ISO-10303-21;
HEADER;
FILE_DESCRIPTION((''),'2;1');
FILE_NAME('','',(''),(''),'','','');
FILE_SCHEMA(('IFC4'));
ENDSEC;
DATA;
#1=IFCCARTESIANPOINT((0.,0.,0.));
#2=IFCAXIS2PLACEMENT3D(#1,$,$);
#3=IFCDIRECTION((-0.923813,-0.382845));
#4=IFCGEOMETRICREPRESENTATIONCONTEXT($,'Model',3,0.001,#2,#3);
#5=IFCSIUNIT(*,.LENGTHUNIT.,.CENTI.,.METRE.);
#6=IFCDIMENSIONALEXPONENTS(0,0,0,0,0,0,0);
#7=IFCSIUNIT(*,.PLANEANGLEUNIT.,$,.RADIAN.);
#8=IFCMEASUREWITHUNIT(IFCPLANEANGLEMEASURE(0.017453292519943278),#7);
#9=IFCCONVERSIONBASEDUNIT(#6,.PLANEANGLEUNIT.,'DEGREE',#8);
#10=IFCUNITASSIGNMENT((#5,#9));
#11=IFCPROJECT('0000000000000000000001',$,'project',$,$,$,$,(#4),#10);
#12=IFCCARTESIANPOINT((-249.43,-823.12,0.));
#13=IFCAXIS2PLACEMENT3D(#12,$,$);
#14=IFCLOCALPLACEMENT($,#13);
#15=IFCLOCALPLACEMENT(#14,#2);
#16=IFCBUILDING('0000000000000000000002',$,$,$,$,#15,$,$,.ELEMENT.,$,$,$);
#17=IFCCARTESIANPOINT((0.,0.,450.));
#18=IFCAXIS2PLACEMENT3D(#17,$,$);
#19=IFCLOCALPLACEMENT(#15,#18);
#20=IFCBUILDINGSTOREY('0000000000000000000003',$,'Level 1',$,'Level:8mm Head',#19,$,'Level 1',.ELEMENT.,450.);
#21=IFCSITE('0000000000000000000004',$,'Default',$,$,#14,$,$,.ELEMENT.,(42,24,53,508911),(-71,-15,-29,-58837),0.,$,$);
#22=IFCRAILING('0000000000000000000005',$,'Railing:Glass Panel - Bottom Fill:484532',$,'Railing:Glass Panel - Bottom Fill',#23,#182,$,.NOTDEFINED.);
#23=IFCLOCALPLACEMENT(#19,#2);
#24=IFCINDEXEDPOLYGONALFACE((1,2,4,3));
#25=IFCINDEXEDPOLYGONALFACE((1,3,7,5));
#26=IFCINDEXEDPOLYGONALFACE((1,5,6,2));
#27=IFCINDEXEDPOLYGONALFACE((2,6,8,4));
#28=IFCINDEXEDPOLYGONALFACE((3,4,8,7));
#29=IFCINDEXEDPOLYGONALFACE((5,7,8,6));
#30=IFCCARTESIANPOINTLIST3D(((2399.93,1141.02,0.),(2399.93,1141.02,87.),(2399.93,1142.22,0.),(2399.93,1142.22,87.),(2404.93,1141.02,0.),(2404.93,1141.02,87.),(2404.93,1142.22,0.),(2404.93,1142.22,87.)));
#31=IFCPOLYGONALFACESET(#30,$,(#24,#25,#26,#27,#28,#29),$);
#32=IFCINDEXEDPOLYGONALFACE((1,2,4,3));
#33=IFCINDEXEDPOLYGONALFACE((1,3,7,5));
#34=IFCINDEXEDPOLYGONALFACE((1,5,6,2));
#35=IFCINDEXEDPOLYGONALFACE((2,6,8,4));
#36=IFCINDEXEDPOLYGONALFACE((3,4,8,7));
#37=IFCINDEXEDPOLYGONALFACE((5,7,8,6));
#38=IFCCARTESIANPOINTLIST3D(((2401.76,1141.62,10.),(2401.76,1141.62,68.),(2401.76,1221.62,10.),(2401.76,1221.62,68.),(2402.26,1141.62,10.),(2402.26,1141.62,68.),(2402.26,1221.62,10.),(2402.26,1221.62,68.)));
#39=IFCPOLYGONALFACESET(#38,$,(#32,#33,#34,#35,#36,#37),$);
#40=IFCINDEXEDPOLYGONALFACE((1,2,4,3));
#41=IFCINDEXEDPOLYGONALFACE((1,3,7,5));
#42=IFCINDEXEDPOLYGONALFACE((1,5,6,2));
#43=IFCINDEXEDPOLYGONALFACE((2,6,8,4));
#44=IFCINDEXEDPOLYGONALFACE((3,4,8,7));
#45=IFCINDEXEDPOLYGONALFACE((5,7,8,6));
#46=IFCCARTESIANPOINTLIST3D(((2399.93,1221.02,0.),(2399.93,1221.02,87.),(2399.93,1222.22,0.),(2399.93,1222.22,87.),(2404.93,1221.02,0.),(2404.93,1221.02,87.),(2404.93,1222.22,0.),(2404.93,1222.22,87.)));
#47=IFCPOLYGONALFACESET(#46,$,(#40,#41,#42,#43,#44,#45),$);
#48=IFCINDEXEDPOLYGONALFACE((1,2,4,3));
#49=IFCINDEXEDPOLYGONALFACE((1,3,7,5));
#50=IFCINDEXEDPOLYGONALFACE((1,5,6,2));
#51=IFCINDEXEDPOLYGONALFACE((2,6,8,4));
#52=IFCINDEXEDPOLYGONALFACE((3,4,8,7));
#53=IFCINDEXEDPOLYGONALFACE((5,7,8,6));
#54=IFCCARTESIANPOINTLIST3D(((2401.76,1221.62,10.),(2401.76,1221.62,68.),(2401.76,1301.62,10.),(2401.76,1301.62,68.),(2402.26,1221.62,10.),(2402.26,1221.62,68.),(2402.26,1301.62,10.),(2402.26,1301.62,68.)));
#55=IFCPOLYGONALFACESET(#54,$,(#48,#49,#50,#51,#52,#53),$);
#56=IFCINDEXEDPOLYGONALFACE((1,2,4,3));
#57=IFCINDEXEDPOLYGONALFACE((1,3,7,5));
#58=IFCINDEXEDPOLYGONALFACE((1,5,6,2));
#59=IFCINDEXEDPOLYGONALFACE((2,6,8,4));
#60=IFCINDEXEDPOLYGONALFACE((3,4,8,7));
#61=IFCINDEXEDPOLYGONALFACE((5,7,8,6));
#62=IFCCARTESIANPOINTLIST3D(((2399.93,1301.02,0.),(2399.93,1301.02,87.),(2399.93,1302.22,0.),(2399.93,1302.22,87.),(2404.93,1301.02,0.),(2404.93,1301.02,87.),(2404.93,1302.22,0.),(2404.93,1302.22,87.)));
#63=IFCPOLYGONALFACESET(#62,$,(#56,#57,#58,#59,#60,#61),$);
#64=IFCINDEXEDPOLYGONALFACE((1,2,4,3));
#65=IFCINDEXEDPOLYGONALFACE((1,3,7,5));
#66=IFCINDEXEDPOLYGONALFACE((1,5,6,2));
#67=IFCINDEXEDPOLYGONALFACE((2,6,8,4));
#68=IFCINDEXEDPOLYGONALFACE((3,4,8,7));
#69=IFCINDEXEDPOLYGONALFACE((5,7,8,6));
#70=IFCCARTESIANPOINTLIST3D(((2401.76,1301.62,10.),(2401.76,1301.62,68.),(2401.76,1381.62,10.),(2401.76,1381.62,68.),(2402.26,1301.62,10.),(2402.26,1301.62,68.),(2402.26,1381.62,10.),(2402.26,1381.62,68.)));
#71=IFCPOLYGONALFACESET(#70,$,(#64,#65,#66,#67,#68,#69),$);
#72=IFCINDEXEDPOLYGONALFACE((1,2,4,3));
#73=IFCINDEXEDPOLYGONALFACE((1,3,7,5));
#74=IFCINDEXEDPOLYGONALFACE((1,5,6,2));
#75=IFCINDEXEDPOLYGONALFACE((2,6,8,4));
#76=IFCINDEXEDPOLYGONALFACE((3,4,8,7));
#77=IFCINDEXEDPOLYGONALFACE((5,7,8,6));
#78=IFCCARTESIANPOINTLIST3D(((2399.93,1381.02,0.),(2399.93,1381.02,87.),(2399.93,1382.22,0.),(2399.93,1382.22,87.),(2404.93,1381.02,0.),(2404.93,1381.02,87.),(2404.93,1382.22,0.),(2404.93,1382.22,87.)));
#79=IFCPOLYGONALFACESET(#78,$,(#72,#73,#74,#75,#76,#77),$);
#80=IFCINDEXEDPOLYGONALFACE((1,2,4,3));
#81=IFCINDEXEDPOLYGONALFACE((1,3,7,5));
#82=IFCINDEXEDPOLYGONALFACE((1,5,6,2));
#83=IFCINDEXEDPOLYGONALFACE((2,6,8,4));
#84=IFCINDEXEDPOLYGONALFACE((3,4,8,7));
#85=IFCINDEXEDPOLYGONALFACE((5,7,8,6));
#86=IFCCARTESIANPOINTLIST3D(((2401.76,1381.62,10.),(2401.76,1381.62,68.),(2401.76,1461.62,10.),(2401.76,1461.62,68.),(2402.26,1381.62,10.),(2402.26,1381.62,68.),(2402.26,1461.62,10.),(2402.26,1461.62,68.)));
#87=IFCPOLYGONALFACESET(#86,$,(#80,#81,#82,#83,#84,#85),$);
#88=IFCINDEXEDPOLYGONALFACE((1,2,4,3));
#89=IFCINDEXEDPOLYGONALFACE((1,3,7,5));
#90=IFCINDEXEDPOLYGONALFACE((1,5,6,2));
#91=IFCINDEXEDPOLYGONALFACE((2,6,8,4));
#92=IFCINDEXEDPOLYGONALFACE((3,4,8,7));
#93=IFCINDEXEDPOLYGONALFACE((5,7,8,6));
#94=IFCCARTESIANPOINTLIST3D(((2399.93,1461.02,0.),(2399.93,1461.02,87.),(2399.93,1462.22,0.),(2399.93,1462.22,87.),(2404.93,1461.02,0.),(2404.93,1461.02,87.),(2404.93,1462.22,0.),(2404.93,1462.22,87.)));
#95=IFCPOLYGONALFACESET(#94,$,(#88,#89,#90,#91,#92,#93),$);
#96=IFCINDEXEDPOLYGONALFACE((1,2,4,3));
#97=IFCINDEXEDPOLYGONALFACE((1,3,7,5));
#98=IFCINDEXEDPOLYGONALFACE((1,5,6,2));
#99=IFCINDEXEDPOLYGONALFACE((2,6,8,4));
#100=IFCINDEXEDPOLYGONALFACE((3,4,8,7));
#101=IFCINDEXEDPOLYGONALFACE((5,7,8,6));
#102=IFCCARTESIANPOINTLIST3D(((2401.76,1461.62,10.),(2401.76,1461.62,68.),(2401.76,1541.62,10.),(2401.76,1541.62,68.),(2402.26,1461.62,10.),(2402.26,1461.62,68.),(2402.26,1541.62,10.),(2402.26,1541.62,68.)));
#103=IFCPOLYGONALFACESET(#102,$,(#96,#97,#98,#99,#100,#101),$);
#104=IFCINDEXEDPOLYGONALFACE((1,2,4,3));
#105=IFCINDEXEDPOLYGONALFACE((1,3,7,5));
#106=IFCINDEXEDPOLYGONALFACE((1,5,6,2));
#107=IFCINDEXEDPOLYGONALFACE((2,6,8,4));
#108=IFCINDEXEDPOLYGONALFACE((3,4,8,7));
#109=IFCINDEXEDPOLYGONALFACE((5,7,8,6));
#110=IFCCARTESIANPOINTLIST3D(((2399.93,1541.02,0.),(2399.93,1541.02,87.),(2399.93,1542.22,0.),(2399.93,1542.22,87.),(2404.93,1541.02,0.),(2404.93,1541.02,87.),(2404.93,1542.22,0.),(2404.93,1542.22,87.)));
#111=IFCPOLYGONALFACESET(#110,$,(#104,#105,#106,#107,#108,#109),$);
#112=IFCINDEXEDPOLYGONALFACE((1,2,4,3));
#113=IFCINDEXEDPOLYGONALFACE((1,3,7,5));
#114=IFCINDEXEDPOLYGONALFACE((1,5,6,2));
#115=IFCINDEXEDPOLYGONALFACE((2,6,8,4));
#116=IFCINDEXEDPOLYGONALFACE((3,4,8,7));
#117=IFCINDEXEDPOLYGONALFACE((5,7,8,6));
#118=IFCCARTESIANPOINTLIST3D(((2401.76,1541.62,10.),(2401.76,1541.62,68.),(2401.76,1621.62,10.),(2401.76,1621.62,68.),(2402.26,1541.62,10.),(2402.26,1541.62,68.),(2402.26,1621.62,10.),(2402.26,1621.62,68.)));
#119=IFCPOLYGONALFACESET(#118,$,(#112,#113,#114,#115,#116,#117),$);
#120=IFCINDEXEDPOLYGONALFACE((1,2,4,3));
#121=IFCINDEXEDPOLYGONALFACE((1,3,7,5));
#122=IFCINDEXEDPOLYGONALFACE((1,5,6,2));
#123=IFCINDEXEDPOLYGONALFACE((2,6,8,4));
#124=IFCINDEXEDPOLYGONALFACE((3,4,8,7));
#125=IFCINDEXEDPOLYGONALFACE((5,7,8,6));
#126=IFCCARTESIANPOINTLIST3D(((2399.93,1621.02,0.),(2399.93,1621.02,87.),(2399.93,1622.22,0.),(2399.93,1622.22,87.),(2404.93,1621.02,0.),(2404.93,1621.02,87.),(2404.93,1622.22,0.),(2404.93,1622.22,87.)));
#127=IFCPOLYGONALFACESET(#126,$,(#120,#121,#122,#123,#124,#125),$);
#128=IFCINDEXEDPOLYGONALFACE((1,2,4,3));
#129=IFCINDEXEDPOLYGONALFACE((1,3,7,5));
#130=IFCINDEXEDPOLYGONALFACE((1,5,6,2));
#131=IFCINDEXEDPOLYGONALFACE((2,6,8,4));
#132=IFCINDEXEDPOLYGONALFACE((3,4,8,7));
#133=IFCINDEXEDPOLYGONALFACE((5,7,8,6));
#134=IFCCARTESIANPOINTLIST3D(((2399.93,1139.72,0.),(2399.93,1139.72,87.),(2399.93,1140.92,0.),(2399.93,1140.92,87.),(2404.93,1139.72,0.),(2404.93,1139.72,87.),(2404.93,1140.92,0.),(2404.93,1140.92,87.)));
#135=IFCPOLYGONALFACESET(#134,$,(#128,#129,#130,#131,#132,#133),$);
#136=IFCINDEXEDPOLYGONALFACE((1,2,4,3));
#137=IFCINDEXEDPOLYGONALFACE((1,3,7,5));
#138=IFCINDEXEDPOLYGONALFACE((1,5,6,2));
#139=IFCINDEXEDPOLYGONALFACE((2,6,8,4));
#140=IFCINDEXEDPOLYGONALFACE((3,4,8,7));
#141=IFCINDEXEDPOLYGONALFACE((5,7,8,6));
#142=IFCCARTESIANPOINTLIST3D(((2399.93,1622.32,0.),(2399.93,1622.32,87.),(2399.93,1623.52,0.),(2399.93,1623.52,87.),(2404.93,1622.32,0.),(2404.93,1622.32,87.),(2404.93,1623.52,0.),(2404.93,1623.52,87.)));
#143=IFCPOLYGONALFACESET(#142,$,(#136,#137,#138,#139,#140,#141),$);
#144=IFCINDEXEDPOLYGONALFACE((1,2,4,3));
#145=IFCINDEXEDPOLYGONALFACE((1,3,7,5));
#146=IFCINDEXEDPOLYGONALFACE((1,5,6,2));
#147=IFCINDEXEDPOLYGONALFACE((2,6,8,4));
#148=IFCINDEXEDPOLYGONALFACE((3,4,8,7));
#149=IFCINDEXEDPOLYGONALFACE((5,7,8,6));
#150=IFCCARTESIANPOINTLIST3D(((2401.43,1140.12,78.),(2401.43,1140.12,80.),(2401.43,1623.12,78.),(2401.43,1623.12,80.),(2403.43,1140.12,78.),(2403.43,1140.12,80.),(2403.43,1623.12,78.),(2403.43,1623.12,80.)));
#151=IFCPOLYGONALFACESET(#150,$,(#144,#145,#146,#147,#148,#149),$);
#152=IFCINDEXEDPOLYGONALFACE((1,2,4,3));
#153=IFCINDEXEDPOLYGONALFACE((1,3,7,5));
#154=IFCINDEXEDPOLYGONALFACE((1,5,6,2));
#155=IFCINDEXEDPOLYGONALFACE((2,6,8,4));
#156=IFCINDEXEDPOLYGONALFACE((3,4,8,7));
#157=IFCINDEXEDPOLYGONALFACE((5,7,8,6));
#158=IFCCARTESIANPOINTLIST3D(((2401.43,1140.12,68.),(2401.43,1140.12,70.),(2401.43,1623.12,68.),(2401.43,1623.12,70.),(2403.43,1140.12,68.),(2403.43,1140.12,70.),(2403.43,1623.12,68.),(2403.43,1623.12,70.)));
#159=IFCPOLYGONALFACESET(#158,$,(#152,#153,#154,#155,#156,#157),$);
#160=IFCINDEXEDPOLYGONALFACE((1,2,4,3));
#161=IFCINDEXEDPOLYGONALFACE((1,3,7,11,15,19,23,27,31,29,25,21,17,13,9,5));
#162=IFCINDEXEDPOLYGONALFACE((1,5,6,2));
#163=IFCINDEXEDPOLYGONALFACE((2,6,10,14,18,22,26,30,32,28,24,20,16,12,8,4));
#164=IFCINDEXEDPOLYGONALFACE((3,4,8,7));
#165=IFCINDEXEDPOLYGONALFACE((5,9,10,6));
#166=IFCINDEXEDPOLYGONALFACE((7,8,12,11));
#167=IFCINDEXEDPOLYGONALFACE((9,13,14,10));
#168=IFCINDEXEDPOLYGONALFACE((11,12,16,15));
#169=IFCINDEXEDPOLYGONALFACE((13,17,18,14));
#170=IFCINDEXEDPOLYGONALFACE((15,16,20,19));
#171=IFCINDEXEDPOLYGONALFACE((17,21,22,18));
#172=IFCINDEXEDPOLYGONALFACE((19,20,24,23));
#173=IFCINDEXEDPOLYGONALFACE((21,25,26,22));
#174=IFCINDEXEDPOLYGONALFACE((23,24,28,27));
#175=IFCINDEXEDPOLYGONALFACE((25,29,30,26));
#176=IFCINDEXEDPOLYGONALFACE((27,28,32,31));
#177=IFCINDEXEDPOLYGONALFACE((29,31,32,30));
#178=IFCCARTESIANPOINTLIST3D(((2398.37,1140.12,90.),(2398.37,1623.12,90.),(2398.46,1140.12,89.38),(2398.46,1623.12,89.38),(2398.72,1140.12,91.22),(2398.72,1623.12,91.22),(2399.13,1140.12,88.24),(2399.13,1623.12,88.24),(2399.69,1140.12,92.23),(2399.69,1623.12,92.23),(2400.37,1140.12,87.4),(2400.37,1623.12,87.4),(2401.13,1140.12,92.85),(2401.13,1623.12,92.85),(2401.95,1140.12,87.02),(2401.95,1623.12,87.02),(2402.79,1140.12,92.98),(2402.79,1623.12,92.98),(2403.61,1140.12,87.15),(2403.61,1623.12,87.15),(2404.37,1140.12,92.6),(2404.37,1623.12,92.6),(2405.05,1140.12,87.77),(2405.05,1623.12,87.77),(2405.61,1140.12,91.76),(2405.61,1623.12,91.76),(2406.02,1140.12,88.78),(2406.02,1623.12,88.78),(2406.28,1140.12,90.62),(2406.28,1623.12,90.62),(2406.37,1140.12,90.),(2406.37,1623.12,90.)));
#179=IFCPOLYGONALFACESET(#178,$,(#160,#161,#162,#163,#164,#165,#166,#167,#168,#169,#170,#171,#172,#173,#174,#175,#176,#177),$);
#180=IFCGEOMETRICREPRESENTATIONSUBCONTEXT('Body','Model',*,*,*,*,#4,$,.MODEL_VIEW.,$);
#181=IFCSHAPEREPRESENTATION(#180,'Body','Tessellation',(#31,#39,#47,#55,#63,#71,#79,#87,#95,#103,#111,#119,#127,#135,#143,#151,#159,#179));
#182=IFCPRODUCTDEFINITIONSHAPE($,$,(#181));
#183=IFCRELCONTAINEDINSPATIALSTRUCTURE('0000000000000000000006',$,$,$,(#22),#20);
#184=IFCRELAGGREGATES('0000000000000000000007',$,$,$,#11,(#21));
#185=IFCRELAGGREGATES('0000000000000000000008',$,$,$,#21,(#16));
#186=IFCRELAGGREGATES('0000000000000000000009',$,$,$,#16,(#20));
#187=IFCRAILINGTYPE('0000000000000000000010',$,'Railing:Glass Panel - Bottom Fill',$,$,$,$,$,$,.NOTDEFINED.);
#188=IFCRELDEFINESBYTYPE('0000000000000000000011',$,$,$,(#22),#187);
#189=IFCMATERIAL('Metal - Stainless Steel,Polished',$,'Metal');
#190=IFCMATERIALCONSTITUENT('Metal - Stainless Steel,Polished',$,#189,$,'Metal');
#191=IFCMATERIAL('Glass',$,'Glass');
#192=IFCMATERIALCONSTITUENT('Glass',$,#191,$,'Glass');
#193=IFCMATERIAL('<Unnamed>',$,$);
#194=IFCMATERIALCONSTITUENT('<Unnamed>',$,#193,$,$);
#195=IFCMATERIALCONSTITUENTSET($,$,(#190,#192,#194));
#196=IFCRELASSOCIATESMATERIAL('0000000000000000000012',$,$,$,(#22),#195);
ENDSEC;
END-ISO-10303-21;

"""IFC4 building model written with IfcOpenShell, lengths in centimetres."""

from ifc_helpers import new_model, entity, si_unit, converted_unit, direction, frame, origin, place, context, subcontext, project, spatial, indexed_curve, outline, extrude, material, constituent, constituent_set, type_object, element, save


model = new_model("IFC4")

# Units and contexts
model_context = context("Model", 3, precision=0.001, world=origin(), true_north=direction((-0.923813, -0.382845)))
body_context = subcontext(model_context, "Body", "Model", "MODEL_VIEW")
ifc_project = project(units=[si_unit("LENGTHUNIT", "METRE", prefix="CENTI"), converted_unit("PLANEANGLEUNIT", "DEGREE", entity("IfcPlaneAngleMeasure", 0.017453292519943278), si_unit("PLANEANGLEUNIT", "RADIAN"), dimensions=[0, 0, 0, 0, 0, 0, 0])], contexts=[model_context])

# Site, building, storey
site_placement = place(None, frame((-249.43, -823.12, 0.0)))
site = spatial("IfcSite", under=ifc_project, at=site_placement, Name="Default", CompositionType="ELEMENT", RefLatitude=(42, 24, 53, 508911), RefLongitude=(-71, -15, -29, -58837), RefElevation=0.0)
building_placement = place(site_placement, origin())
building = spatial("IfcBuilding", under=site, at=building_placement, CompositionType="ELEMENT")
storey_placement = place(building_placement, frame((0.0, 0.0, 450.0)))
storey = spatial("IfcBuildingStorey", under=building, at=storey_placement, Name="Level 1", ObjectType="Level:8mm Head", LongName="Level 1", CompositionType="ELEMENT", Elevation=450.0)

# Shared definitions
ifc_material_1 = material(Name="<Unnamed>")

# Railing
ifc_material_2 = material(Name="Metal - Stainless Steel,Polished", Category="Metal")
ifc_constituent_1 = constituent(ifc_material_2, Name="Metal - Stainless Steel,Polished", Category="Metal")
ifc_material_3 = material(Name="Glass", Category="Glass")
ifc_constituent_2 = constituent(ifc_material_3, Name="Glass", Category="Glass")
ifc_constituent_3 = constituent(ifc_material_1, Name="<Unnamed>")
ifc_constituent_set_1 = constituent_set(constituents=[ifc_constituent_1, ifc_constituent_2, ifc_constituent_3])
railing_type = type_object("IfcRailingType", Name="Railing:Glass Panel - Bottom Fill", PredefinedType="NOTDEFINED")
railing_placement = place(storey_placement, frame((2398.21, 1139.72, 0.0)))
element("IfcRailing", 1, at=railing_placement, inside=storey, type_object=railing_type, material=ifc_constituent_set_1, Name="Railing:Glass Panel - Bottom Fill:484532", ObjectType="Railing:Glass Panel - Bottom Fill", PredefinedType="NOTDEFINED", context=body_context, shape_type="SweptSolid", body=[
    extrude(outline(indexed_curve([(-2.5, -0.6), (2.5, -0.6), (2.5, 0.6), (-2.5, 0.6), (-2.5, -0.6)], self_intersect=False)), frame((4.22, 1.9, 0.0), z_axis=(0.0, 0.0, 1.0), x_axis=(-1.0, 0.0, 0.0)), (0.0, 0.0, 1.0), 87.0),
    extrude(outline(indexed_curve([(-0.25, -40.0), (0.25, -40.0), (0.25, 40.0), (-0.25, 40.0), (-0.25, -40.0)], self_intersect=False)), frame((3.8, 41.9, 10.0), z_axis=(0.0, 0.0, 1.0), x_axis=(-1.0, 0.0, 0.0)), (0.0, 0.0, 1.0), 58.0),
    extrude(outline(indexed_curve([(-2.5, -0.6), (2.5, -0.6), (2.5, 0.6), (-2.5, 0.6), (-2.5, -0.6)], self_intersect=False)), frame((4.22, 81.9, 0.0), z_axis=(0.0, 0.0, 1.0), x_axis=(-1.0, 0.0, 0.0)), (0.0, 0.0, 1.0), 87.0),
    extrude(outline(indexed_curve([(-0.25, -40.0), (0.25, -40.0), (0.25, 40.0), (-0.25, 40.0), (-0.25, -40.0)], self_intersect=False)), frame((3.8, 121.9, 10.0), z_axis=(0.0, 0.0, 1.0), x_axis=(-1.0, 0.0, 0.0)), (0.0, 0.0, 1.0), 58.0),
    extrude(outline(indexed_curve([(-2.5, -0.6), (2.5, -0.6), (2.5, 0.6), (-2.5, 0.6), (-2.5, -0.6)], self_intersect=False)), frame((4.22, 161.9, 0.0), z_axis=(0.0, 0.0, 1.0), x_axis=(-1.0, 0.0, 0.0)), (0.0, 0.0, 1.0), 87.0),
    extrude(outline(indexed_curve([(-0.25, -40.0), (0.25, -40.0), (0.25, 40.0), (-0.25, 40.0), (-0.25, -40.0)], self_intersect=False)), frame((3.8, 201.9, 10.0), z_axis=(0.0, 0.0, 1.0), x_axis=(-1.0, 0.0, 0.0)), (0.0, 0.0, 1.0), 58.0),
    extrude(outline(indexed_curve([(-2.5, -0.6), (2.5, -0.6), (2.5, 0.6), (-2.5, 0.6), (-2.5, -0.6)], self_intersect=False)), frame((4.22, 241.9, 0.0), z_axis=(0.0, 0.0, 1.0), x_axis=(-1.0, 0.0, 0.0)), (0.0, 0.0, 1.0), 87.0),
    extrude(outline(indexed_curve([(-0.25, -40.0), (0.25, -40.0), (0.25, 40.0), (-0.25, 40.0), (-0.25, -40.0)], self_intersect=False)), frame((3.8, 281.9, 10.0), z_axis=(0.0, 0.0, 1.0), x_axis=(-1.0, 0.0, 0.0)), (0.0, 0.0, 1.0), 58.0),
    extrude(outline(indexed_curve([(-2.5, -0.6), (2.5, -0.6), (2.5, 0.6), (-2.5, 0.6), (-2.5, -0.6)], self_intersect=False)), frame((4.22, 321.9, 0.0), z_axis=(0.0, 0.0, 1.0), x_axis=(-1.0, 0.0, 0.0)), (0.0, 0.0, 1.0), 87.0),
    extrude(outline(indexed_curve([(-0.25, -40.0), (0.25, -40.0), (0.25, 40.0), (-0.25, 40.0), (-0.25, -40.0)], self_intersect=False)), frame((3.8, 361.9, 10.0), z_axis=(0.0, 0.0, 1.0), x_axis=(-1.0, 0.0, 0.0)), (0.0, 0.0, 1.0), 58.0),
    extrude(outline(indexed_curve([(-2.5, -0.6), (2.5, -0.6), (2.5, 0.6), (-2.5, 0.6), (-2.5, -0.6)], self_intersect=False)), frame((4.22, 401.9, 0.0), z_axis=(0.0, 0.0, 1.0), x_axis=(-1.0, 0.0, 0.0)), (0.0, 0.0, 1.0), 87.0),
    extrude(outline(indexed_curve([(-0.25, -40.0), (0.25, -40.0), (0.25, 40.0), (-0.25, 40.0), (-0.25, -40.0)], self_intersect=False)), frame((3.8, 441.9, 10.0), z_axis=(0.0, 0.0, 1.0), x_axis=(-1.0, 0.0, 0.0)), (0.0, 0.0, 1.0), 58.0),
    extrude(outline(indexed_curve([(-2.5, -0.6), (2.5, -0.6), (2.5, 0.6), (-2.5, 0.6), (-2.5, -0.6)], self_intersect=False)), frame((4.22, 481.9, 0.0), z_axis=(0.0, 0.0, 1.0), x_axis=(-1.0, 0.0, 0.0)), (0.0, 0.0, 1.0), 87.0),
    extrude(outline(indexed_curve([(-2.5, -0.6), (2.5, -0.6), (2.5, 0.6), (-2.5, 0.6), (-2.5, -0.6)], self_intersect=False)), frame((4.22, 0.6, 0.0), z_axis=(0.0, 0.0, 1.0), x_axis=(-1.0, 0.0, 0.0)), (0.0, 0.0, 1.0), 87.0),
    extrude(outline(indexed_curve([(-2.5, -0.6), (2.5, -0.6), (2.5, 0.6), (-2.5, 0.6), (-2.5, -0.6)], self_intersect=False)), frame((4.22, 483.2, 0.0), z_axis=(0.0, 0.0, 1.0), x_axis=(-1.0, 0.0, 0.0)), (0.0, 0.0, 1.0), 87.0),
    extrude(outline(indexed_curve([(-241.5, -1.0), (241.5, -1.0), (241.5, 1.0), (-241.5, 1.0), (-241.5, -1.0)], self_intersect=False)), frame((4.22, 241.9, 78.0), z_axis=(0.0, 0.0, 1.0), x_axis=(0.0, -1.0, 0.0)), (0.0, 0.0, 1.0), 2.0),
    extrude(outline(indexed_curve([(-241.5, -1.0), (241.5, -1.0), (241.5, 1.0), (-241.5, 1.0), (-241.5, -1.0)], self_intersect=False)), frame((4.22, 241.9, 68.0), z_axis=(0.0, 0.0, 1.0), x_axis=(0.0, -1.0, 0.0)), (0.0, 0.0, 1.0), 2.0),
    extrude(outline(indexed_curve([(-1.09, -3.85), (0.18, -3.85), (1.42, -3.18), (2.41, -1.97), (2.98, -0.41), (3.04, 1.22), (2.58, 2.63), (1.67, 3.59), (1.09, 3.85), (-0.18, 3.85), (-1.42, 3.18), (-2.41, 1.97), (-2.98, 0.41), (-3.04, -1.22), (-2.58, -2.63), (-1.67, -3.59), (-1.09, -3.85)], self_intersect=False)), frame((4.16, 0.4, 90.0), z_axis=(0.0, 1.0, 0.0), x_axis=(-0.27267, 0.0, -0.962108)), (0.0, 0.0, 1.0), 483.0),
])

save(model, "model.ifc")
